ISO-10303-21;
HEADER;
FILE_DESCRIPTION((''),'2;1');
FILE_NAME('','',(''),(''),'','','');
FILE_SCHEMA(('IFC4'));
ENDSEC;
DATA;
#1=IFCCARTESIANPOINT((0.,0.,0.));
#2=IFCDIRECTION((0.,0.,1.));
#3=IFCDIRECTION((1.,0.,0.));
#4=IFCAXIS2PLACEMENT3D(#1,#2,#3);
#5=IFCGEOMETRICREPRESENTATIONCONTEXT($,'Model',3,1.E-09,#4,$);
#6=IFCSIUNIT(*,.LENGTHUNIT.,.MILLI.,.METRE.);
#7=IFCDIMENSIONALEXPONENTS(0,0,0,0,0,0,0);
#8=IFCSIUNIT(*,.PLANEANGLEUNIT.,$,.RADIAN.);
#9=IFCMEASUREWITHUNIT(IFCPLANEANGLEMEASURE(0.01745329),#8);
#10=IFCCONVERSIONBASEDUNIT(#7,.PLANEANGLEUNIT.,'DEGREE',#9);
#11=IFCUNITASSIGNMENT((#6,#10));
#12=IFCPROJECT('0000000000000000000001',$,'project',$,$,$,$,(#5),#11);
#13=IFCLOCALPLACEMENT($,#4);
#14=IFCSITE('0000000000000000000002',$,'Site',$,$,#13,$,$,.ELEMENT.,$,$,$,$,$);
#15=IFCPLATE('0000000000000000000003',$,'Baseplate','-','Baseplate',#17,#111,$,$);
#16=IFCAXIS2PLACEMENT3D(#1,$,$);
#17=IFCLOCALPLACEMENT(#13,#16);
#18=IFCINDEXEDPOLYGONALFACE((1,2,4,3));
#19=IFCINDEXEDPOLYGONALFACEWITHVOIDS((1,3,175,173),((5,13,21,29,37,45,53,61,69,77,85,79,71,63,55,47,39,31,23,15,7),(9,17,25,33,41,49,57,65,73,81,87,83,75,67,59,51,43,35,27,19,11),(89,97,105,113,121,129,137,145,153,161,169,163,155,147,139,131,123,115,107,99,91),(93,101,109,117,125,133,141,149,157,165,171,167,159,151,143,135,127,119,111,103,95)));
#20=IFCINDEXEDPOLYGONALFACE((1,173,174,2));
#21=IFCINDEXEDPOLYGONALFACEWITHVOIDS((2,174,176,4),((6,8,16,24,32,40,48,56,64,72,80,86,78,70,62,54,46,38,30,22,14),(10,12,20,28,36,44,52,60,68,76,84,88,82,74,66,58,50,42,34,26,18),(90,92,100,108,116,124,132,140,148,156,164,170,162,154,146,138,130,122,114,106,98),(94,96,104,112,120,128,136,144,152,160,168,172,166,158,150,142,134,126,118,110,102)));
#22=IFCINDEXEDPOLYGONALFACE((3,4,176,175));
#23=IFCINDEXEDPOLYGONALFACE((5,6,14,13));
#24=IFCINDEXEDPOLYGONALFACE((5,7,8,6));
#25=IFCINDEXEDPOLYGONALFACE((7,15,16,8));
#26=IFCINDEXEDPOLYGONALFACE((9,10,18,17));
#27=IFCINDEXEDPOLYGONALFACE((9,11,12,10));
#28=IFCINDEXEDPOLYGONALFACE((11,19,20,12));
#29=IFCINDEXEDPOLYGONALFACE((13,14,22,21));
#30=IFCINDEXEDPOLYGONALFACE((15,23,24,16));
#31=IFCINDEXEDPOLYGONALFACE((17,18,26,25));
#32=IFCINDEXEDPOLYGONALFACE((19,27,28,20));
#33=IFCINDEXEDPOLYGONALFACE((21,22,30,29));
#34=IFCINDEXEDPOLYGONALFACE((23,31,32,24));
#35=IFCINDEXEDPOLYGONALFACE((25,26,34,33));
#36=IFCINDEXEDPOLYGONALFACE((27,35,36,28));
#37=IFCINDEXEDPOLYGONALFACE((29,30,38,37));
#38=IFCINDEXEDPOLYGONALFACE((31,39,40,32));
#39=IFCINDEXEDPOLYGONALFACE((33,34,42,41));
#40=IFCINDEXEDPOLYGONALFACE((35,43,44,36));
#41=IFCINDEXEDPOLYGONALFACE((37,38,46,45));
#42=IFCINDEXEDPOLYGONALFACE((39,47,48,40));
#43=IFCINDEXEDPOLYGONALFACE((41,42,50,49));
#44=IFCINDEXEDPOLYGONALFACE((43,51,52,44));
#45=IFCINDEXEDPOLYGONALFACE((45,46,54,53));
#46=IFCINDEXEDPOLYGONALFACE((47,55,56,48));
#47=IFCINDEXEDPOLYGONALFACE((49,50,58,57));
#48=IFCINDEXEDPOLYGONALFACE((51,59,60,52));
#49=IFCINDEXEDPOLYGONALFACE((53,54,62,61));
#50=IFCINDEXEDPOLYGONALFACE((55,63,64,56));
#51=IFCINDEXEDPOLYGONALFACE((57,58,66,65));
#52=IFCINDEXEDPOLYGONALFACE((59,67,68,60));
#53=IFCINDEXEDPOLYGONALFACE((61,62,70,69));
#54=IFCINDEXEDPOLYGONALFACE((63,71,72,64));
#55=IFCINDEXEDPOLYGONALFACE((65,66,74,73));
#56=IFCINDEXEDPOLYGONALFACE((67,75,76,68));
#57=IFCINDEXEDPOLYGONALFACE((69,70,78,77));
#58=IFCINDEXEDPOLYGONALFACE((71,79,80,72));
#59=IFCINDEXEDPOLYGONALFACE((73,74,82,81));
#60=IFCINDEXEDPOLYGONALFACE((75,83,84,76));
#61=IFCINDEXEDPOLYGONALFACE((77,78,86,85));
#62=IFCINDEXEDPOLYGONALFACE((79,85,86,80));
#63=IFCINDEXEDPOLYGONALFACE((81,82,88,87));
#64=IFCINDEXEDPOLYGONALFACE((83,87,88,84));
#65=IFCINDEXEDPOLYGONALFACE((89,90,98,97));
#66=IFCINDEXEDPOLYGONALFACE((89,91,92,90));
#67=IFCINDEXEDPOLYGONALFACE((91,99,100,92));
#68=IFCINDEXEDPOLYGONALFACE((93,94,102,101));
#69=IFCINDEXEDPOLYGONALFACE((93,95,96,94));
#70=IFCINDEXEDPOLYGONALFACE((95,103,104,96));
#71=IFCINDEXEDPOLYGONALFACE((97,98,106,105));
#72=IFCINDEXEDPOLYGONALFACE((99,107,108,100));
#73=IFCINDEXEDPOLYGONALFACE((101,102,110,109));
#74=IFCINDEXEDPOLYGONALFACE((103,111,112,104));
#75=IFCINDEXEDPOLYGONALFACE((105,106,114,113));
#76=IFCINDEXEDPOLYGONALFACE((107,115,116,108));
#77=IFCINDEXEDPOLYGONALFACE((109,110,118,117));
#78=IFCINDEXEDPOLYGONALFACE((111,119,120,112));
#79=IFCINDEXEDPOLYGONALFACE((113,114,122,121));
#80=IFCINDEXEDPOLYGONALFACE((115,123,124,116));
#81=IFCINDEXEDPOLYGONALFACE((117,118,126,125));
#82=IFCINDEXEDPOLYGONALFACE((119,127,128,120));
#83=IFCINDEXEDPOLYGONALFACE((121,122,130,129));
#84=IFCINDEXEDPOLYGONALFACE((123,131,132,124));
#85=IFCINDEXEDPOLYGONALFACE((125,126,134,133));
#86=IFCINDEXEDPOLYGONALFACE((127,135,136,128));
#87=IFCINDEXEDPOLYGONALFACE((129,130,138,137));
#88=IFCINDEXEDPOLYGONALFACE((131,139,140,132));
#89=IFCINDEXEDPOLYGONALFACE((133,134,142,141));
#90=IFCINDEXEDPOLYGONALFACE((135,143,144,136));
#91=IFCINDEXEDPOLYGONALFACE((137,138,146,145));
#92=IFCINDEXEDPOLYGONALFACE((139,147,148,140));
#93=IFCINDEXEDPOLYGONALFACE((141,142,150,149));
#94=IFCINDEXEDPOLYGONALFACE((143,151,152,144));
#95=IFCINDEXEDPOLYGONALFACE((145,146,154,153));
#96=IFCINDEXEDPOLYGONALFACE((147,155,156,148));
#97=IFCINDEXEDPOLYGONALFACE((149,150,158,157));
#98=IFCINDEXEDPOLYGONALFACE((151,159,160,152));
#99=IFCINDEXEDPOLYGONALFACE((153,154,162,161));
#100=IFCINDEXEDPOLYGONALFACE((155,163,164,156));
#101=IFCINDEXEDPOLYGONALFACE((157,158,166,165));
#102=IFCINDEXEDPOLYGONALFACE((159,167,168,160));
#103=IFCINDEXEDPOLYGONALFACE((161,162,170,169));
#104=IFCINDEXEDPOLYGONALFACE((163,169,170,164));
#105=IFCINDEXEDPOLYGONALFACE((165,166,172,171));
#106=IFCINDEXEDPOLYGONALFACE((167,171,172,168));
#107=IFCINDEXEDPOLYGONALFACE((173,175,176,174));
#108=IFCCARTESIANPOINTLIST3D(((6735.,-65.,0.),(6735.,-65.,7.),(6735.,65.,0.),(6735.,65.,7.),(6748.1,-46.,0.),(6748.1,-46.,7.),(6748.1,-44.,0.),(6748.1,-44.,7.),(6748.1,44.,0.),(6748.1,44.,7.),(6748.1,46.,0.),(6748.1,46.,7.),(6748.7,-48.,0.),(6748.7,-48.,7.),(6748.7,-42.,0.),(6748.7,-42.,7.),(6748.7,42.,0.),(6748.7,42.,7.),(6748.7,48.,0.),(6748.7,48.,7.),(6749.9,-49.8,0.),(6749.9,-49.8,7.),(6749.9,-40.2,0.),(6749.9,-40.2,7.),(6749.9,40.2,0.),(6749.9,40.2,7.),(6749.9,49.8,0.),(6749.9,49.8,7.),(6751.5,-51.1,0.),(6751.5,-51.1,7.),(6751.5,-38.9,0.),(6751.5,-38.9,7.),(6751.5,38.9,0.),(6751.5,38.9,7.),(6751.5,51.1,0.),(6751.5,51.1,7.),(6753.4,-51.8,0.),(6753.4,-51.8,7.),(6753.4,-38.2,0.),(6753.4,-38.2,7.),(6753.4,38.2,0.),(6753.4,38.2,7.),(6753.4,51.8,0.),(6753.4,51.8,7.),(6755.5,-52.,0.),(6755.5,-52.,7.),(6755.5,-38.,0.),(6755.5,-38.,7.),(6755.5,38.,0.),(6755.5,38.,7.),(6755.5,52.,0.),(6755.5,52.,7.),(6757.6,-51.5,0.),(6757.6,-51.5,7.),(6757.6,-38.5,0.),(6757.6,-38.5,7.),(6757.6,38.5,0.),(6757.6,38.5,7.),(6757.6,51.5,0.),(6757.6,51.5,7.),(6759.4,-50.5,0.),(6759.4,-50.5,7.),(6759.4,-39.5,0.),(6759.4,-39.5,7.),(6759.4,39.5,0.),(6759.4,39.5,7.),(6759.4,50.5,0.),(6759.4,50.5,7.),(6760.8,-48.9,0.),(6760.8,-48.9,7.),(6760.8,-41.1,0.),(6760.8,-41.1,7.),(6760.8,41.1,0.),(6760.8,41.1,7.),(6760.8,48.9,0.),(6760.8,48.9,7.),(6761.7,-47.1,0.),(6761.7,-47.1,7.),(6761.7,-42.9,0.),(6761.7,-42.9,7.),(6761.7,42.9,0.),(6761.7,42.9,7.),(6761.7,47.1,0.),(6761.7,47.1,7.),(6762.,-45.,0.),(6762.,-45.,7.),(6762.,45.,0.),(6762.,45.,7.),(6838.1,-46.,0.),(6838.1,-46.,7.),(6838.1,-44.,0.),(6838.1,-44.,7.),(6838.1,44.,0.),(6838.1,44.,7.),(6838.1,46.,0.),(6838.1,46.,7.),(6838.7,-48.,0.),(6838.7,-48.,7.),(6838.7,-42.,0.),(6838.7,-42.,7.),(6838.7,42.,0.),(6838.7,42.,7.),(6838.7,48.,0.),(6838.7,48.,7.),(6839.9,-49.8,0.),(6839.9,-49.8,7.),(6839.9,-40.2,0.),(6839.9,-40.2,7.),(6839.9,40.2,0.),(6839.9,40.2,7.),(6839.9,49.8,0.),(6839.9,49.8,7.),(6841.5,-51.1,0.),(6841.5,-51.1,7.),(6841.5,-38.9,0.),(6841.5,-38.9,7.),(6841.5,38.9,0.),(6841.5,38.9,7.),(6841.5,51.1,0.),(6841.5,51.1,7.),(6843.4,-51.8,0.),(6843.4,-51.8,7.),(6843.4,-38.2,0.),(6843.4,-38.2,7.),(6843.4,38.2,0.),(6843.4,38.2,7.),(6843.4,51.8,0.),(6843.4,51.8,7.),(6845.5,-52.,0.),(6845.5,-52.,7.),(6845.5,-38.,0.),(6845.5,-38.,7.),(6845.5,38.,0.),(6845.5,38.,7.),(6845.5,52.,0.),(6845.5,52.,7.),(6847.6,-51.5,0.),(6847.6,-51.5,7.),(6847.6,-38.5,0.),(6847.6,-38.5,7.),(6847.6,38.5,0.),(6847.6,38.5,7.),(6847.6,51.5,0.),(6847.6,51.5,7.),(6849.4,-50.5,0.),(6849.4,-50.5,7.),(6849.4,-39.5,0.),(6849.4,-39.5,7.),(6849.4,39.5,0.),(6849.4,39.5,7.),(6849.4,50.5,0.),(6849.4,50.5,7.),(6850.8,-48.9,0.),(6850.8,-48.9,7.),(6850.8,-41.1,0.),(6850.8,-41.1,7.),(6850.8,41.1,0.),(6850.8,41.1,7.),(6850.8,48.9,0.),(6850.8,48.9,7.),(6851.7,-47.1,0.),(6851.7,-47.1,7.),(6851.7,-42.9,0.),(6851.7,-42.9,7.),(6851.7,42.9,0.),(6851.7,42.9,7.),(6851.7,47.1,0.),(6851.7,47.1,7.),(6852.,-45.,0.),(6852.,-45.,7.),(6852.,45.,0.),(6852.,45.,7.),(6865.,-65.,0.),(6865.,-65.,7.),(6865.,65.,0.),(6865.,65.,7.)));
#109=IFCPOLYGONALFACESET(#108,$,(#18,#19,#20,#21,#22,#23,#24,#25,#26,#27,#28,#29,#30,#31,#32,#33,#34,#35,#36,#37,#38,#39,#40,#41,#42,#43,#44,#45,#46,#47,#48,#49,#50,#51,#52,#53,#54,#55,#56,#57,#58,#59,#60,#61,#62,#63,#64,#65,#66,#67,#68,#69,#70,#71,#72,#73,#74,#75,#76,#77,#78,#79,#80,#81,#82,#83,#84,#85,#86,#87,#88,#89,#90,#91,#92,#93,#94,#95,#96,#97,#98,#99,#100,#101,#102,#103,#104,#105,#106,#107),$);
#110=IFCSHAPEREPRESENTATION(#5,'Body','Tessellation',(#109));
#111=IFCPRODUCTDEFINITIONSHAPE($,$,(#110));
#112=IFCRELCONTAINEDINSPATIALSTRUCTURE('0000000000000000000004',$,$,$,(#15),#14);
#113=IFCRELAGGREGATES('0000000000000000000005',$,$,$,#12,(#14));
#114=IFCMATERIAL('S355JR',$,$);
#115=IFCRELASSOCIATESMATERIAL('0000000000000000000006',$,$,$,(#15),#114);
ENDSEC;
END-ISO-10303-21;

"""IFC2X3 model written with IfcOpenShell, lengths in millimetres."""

from ifc_helpers import new_model, entity, si_unit, converted_unit, frame, frame_2d, origin, origin_with_axes, place, context, project, spatial, polyline, circle, outline, extrude, material, element, save


model = new_model("IFC2X3")

# Units and contexts
model_context = context("Model", 3, precision=1e-09, world=origin_with_axes())
ifc_project = project(units=[si_unit("LENGTHUNIT", "METRE", prefix="MILLI"), converted_unit("PLANEANGLEUNIT", "DEGREE", entity("IfcPlaneAngleMeasure", 0.01745329), si_unit("PLANEANGLEUNIT", "RADIAN"), dimensions=[0, 0, 0, 0, 0, 0, 0])], contexts=[model_context])

# Site
site_placement = place(None, origin_with_axes())
site = spatial("IfcSite", under=ifc_project, at=site_placement, Name="Site", CompositionType="ELEMENT")

# Shared definitions
ifc_material = material(Name="S355JR")

# Plate, openings
plate_1_placement = place(None, frame((6735.0, 65.0, 7.0), z_axis=(0.0, 0.0, -1.0), x_axis=(1.0, 0.0, 0.0)))
plate_1 = element("IfcPlate", 1, at=plate_1_placement, inside=site, material=ifc_material, Name="Baseplate", Description="-", ObjectType="Baseplate", context=model_context, shape_type="SweptSolid", body=[
    extrude(outline(polyline([(0.0, 0.0), (130.0, 0.0), (130.0, 130.0), (0.0, 130.0), (0.0, 0.0)])), origin_with_axes(), (0.0, 0.0, 1.0), 7.0),
])
opening_1_placement = place(plate_1_placement, frame((20.0, 65.0, 7.5), z_axis=(0.0, 0.0, -1.0), x_axis=(1.0, 0.0, 0.0)))
element("IfcOpeningElement", 2, at=opening_1_placement, cuts=plate_1, ObjectType="Opening", context=model_context, shape_type="SweptSolid", body=[
    extrude(circle(Radius=7.0, at=frame_2d((0.0, 45.0), x_axis=(1.0, 0.0))), origin(), (0.0, 0.0, 1.0), 8.0),
])
opening_2_placement = place(plate_1_placement, frame((20.0, 65.0, 7.5), z_axis=(0.0, 0.0, -1.0), x_axis=(1.0, 0.0, 0.0)))
element("IfcOpeningElement", 3, at=opening_2_placement, cuts=plate_1, ObjectType="Opening", context=model_context, shape_type="SweptSolid", body=[
    extrude(circle(Radius=7.0, at=frame_2d((0.0, -45.0), x_axis=(1.0, 0.0))), origin(), (0.0, 0.0, 1.0), 8.0),
])
opening_3_placement = place(plate_1_placement, frame((110.0, 65.0, 7.5), z_axis=(0.0, 0.0, -1.0), x_axis=(1.0, 0.0, 0.0)))
element("IfcOpeningElement", 4, at=opening_3_placement, cuts=plate_1, ObjectType="Opening", context=model_context, shape_type="SweptSolid", body=[
    extrude(circle(Radius=7.0, at=frame_2d((0.0, 45.0), x_axis=(1.0, 0.0))), origin(), (0.0, 0.0, 1.0), 8.0),
])
opening_4_placement = place(plate_1_placement, frame((110.0, 65.0, 7.5), z_axis=(0.0, 0.0, -1.0), x_axis=(1.0, 0.0, 0.0)))
element("IfcOpeningElement", 5, at=opening_4_placement, cuts=plate_1, ObjectType="Opening", context=model_context, shape_type="SweptSolid", body=[
    extrude(circle(Radius=7.0, at=frame_2d((0.0, -45.0), x_axis=(1.0, 0.0))), origin(), (0.0, 0.0, 1.0), 8.0),
])

save(model, "model.ifc")
